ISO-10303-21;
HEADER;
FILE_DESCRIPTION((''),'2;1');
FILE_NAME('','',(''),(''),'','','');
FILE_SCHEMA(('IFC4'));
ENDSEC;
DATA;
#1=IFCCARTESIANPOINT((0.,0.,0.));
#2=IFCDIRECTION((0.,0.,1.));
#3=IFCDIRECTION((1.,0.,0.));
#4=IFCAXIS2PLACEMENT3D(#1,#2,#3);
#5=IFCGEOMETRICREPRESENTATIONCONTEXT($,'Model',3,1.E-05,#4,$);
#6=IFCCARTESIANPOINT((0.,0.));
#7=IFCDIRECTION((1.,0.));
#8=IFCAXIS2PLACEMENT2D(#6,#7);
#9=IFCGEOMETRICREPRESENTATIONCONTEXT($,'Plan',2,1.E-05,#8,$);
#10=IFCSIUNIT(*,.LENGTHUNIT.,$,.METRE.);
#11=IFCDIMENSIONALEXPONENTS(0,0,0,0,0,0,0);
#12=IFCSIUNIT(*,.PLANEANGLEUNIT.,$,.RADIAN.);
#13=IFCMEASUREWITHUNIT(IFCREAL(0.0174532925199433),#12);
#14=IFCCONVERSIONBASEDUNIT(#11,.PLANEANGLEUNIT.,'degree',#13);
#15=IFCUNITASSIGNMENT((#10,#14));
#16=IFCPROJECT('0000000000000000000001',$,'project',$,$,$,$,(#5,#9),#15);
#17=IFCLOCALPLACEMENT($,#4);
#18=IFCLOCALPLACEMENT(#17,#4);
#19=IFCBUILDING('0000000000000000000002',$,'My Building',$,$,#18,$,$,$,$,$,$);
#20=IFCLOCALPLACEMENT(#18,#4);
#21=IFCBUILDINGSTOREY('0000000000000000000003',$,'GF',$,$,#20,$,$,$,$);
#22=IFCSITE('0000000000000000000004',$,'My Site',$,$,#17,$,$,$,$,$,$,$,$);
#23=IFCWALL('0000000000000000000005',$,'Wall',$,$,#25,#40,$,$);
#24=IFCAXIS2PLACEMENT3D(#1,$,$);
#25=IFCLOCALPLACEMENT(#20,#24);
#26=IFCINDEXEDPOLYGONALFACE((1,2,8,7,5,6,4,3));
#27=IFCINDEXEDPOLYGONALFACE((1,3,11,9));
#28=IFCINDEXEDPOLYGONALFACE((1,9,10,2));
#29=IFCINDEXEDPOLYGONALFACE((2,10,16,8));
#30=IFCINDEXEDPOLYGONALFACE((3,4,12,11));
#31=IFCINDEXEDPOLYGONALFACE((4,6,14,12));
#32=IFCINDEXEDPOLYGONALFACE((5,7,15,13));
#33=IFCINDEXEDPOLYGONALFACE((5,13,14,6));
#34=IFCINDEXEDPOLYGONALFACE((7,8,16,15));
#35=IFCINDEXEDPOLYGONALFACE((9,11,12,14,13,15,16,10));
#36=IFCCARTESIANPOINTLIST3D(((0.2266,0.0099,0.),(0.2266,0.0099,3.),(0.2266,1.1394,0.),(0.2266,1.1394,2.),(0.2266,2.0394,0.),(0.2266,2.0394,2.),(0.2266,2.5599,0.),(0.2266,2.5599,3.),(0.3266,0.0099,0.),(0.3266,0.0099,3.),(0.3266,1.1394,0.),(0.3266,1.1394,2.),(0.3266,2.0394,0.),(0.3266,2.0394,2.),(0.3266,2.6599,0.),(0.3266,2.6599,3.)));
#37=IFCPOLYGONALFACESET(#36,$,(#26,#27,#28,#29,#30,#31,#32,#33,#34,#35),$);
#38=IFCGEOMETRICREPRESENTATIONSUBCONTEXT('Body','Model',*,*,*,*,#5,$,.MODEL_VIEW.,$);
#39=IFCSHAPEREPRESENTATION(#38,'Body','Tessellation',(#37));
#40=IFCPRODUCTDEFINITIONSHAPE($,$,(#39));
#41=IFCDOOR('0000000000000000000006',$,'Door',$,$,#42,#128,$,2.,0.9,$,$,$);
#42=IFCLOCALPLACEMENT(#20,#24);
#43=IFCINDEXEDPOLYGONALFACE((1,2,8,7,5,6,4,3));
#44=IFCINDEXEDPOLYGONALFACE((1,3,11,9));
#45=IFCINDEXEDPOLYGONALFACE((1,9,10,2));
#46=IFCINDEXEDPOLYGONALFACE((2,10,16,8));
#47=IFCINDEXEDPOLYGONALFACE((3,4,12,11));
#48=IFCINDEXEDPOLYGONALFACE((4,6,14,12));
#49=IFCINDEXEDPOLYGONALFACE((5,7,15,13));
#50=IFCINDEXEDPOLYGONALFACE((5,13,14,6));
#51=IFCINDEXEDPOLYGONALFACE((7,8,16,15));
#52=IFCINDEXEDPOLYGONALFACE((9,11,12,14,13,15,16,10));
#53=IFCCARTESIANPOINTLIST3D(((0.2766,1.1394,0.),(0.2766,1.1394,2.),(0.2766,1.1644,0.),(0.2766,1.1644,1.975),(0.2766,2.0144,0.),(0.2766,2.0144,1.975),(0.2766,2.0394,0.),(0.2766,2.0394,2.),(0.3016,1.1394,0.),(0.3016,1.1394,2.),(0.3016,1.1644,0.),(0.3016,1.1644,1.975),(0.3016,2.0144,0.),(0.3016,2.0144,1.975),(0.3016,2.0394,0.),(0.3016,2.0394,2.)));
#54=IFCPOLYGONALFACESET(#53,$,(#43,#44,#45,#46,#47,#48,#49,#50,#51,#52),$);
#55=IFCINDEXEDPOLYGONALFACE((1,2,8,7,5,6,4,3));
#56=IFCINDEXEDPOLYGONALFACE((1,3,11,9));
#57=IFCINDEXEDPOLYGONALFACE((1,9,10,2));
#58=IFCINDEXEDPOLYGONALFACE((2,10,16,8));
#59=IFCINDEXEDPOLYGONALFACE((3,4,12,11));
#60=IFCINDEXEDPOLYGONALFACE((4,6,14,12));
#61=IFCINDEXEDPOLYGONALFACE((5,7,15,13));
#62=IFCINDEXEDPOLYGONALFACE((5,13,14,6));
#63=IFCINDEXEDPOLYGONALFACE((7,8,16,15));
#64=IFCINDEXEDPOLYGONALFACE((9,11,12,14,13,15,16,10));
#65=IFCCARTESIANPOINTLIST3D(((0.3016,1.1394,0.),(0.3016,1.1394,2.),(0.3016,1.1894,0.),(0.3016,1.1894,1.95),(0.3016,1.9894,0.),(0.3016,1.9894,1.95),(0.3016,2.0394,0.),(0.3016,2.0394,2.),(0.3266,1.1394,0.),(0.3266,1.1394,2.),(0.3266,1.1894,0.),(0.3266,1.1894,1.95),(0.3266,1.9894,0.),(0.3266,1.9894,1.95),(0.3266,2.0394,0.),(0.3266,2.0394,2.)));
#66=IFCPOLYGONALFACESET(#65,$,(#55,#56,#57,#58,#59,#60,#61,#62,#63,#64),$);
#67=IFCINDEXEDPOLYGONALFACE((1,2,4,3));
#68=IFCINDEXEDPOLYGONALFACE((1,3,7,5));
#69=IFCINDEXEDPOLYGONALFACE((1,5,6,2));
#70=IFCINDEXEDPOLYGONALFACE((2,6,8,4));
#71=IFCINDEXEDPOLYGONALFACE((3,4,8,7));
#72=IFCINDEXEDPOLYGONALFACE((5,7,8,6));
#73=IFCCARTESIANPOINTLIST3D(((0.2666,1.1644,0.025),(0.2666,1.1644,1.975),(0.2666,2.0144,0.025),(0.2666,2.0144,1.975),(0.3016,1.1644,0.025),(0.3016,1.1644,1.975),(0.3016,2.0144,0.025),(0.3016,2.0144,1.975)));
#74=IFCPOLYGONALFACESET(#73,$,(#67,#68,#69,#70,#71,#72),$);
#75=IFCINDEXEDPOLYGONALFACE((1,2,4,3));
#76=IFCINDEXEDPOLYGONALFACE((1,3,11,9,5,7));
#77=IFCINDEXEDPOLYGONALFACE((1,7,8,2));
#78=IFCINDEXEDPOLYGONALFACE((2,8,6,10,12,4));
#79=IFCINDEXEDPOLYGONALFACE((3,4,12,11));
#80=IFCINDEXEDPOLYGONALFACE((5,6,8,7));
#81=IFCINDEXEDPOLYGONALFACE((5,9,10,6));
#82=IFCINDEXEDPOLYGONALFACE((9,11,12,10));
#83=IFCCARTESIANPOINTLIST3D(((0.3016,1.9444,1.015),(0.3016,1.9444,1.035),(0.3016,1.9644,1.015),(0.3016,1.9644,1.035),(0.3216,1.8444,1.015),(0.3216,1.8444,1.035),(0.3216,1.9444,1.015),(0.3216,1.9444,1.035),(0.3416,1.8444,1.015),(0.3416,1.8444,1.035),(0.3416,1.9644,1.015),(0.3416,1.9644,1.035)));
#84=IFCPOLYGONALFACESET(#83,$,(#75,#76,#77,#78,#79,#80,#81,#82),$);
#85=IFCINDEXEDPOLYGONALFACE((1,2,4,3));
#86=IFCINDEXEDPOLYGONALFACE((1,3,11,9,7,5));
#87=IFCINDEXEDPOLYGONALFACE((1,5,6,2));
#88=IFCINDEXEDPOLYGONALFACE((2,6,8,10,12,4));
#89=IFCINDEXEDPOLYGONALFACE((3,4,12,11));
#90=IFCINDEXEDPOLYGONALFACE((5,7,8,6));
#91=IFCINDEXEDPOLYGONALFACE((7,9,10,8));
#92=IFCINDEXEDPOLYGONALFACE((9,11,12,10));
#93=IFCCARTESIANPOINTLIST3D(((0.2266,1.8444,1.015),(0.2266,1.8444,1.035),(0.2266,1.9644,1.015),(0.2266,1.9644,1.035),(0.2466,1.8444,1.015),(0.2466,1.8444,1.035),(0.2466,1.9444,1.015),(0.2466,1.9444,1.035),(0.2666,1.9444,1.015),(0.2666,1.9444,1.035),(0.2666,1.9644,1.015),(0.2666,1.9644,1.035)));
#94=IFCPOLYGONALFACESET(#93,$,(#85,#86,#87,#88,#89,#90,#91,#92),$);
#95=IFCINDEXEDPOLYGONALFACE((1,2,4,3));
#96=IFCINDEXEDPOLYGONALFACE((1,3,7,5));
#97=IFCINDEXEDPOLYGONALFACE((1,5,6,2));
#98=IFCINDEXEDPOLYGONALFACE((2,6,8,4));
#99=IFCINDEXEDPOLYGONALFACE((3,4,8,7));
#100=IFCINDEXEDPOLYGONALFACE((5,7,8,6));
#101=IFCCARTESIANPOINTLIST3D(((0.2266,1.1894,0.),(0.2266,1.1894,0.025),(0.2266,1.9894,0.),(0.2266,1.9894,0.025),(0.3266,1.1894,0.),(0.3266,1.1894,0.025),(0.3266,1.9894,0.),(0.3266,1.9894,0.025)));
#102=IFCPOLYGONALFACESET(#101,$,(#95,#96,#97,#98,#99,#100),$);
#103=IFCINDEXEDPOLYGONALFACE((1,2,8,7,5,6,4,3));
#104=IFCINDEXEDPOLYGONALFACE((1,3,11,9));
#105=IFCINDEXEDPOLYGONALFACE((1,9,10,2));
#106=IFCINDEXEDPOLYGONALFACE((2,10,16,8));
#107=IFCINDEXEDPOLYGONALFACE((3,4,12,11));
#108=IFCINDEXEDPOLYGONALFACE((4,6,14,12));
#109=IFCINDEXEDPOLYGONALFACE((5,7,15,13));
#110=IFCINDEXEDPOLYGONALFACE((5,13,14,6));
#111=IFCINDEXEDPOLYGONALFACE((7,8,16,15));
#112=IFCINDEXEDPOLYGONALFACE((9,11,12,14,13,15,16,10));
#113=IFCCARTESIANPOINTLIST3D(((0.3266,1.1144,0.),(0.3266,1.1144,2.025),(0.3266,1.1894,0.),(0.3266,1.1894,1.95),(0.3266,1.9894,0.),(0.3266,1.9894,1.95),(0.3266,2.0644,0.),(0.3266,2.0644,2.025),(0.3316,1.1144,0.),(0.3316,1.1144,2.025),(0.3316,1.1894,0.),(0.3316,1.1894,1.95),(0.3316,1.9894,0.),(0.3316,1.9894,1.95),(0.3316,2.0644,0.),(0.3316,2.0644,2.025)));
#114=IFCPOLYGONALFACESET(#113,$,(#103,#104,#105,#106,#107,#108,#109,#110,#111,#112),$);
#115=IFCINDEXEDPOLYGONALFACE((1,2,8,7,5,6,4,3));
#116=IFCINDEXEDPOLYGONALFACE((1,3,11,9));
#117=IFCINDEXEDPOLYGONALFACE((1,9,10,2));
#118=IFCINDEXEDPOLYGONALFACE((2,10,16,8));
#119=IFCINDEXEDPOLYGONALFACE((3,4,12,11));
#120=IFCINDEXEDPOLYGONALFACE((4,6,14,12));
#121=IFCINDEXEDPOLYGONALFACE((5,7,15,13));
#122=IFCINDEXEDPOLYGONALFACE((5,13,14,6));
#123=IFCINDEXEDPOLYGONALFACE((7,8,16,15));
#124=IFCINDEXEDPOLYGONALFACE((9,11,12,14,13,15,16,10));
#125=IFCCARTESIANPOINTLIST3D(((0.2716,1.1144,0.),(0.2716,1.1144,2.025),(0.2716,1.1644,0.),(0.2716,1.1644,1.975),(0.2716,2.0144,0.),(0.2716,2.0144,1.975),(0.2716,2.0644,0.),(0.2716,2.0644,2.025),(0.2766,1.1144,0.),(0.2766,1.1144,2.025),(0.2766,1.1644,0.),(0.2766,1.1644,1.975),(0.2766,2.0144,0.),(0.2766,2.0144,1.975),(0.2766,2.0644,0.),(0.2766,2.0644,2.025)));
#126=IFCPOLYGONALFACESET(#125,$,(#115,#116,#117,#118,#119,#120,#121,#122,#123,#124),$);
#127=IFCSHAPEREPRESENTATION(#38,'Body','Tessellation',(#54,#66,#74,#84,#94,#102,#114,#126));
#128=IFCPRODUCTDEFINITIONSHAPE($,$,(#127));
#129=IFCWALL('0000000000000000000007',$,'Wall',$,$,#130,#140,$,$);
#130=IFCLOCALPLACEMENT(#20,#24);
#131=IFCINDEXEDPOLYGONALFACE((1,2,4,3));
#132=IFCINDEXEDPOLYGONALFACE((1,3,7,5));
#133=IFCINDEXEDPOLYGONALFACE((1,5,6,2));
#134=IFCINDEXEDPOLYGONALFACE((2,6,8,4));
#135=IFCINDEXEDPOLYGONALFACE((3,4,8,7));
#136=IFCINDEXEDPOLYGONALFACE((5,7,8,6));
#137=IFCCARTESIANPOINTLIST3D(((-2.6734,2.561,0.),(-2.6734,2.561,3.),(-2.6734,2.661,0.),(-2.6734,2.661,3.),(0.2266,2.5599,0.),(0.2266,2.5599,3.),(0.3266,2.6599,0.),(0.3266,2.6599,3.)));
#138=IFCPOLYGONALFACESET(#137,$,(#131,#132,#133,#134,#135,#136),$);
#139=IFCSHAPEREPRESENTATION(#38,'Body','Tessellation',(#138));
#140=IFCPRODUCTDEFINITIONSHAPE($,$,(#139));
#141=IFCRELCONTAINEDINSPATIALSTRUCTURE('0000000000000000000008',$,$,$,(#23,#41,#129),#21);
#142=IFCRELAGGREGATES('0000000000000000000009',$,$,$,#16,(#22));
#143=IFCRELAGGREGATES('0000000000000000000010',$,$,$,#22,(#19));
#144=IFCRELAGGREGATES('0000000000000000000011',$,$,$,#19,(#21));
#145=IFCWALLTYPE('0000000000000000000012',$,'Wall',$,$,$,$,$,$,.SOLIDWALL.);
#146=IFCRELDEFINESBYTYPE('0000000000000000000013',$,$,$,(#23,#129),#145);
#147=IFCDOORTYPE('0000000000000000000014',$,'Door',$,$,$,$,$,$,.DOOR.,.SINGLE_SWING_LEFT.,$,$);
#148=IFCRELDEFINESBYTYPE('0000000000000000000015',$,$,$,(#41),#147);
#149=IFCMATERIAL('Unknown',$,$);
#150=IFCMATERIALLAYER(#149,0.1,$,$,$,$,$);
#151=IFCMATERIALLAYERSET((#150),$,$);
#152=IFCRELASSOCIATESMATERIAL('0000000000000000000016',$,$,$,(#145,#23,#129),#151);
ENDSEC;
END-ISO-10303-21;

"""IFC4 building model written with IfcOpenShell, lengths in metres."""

from ifc_helpers import new_model, entity, si_unit, converted_unit, frame, origin_with_axes, origin_2d_with_axis, place, context, subcontext, project, spatial, line, indexed_curve, outline, extrude, shape, source, transform, mapped, material, layer, layer_set, layer_usage, type_object, type_shapes, element, fill, save


model = new_model("IFC4")

# Units and contexts
model_context = context("Model", 3, precision=1e-05, world=origin_with_axes())
plan_context = context("Plan", 2, precision=1e-05, world=origin_2d_with_axis())
body_context_1 = subcontext(model_context, "Body", "Model", "MODEL_VIEW")
body_context_2 = subcontext(plan_context, "Body", "Plan", "PLAN_VIEW")
ifc_project = project(units=[si_unit("LENGTHUNIT", "METRE"), converted_unit("PLANEANGLEUNIT", "degree", entity("IfcReal", 0.0174532925199433), si_unit("PLANEANGLEUNIT", "RADIAN"), dimensions=[0, 0, 0, 0, 0, 0, 0])], contexts=[model_context, plan_context])

# Site, building, storey
site_placement = place(None, origin_with_axes())
site = spatial("IfcSite", under=ifc_project, at=site_placement, Name="My Site")
building_placement = place(site_placement, origin_with_axes())
building = spatial("IfcBuilding", under=site, at=building_placement, Name="My Building")
storey_placement = place(building_placement, origin_with_axes())
storey = spatial("IfcBuildingStorey", under=building, at=storey_placement, Name="GF")

# Shared definitions
ifc_material = material(Name="Unknown")

# Shared definitions
ifc_layer_1 = layer(ifc_material, 0.1)
ifc_layer_set_1 = layer_set([ifc_layer_1])
wall_type = type_object("IfcWallType", Name="Wall", PredefinedType="SOLIDWALL", material=ifc_layer_set_1)
shared_shape_1 = source(origin_with_axes(), body_context_1, "Body", "SweptSolid", [
    extrude(outline(indexed_curve([(0.0, 0.0), (0.9, 0.0), (0.9, 2.0), (0.0, 2.0)], segments=[line(1, 2, 3, 4, 1)])), frame((0.0, -0.6, 0.0), z_axis=(0.0, -1.0, 0.0), x_axis=(1.0, 0.0, 0.0)), (0.0, 0.0, -1.0), 1.2),
])
door_type = type_object("IfcDoorType", Name="Door", OperationType="SINGLE_SWING_LEFT", PredefinedType="DOOR")
shared_shape_2 = source(origin_with_axes(), body_context_1, "Body", "SweptSolid", [
    extrude(outline(indexed_curve([(0.0, 0.0), (0.0, 2.0), (0.9, 2.0), (0.9, 0.0), (0.875, 0.0), (0.875, 1.975), (0.025, 1.975), (0.025, 0.0)], segments=[line(1, 2, 3, 4, 5, 6, 7, 8, 1)])), frame((0.0, 0.025, 0.0), z_axis=(0.0, -1.0, 0.0), x_axis=(1.0, 0.0, 0.0)), (0.0, 0.0, -1.0), 0.025),
    extrude(outline(indexed_curve([(0.0, 0.0), (0.0, 2.0), (0.9, 2.0), (0.9, 0.0), (0.85, 0.0), (0.85, 1.95), (0.05, 1.95), (0.05, 0.0)], segments=[line(1, 2, 3, 4, 5, 6, 7, 8, 1)])), frame((0.0, 0.0, 0.0), z_axis=(0.0, -1.0, 0.0), x_axis=(1.0, 0.0, 0.0)), (0.0, 0.0, -1.0), 0.025),
    extrude(outline(indexed_curve([(0.0, 0.0), (0.85, 0.0), (0.85, 0.035), (0.0, 0.035)], segments=[line(1, 2, 3, 4, 1)])), frame((0.025, 0.025, 0.025), z_axis=(0.0, 0.0, 1.0), x_axis=(1.0, 0.0, 0.0)), (0.0, 0.0, 1.0), 1.95),
    extrude(outline(indexed_curve([(0.0, 0.0), (0.0, -0.04), (-0.12, -0.04), (-0.12, -0.02), (-0.02, -0.02), (-0.02, 0.0)], segments=[line(1, 2, 3, 4, 5, 6, 1)])), frame((0.825, 0.025, 1.015), z_axis=(0.0, 0.0, 1.0), x_axis=(1.0, 0.0, 0.0)), (0.0, 0.0, 1.0), 0.02),
    extrude(outline(indexed_curve([(0.0, 0.0), (0.0, 0.04), (-0.12, 0.04), (-0.12, 0.02), (-0.02, 0.02), (-0.02, 0.0)], segments=[line(1, 2, 3, 4, 5, 6, 1)])), frame((0.825, 0.06, 1.015), z_axis=(0.0, 0.0, 1.0), x_axis=(1.0, 0.0, 0.0)), (0.0, 0.0, 1.0), 0.02),
    extrude(outline(indexed_curve([(0.0, 0.0), (0.8, 0.0), (0.8, 0.1), (0.0, 0.1)], segments=[line(1, 2, 3, 4, 1)])), frame((0.05, 0.0, 0.0), z_axis=(0.0, 0.0, 1.0), x_axis=(1.0, 0.0, 0.0)), (0.0, 0.0, 1.0), 0.025),
    extrude(outline(indexed_curve([(0.0, 0.0), (0.0, 2.025), (0.95, 2.025), (0.95, 0.0), (0.875, 0.0), (0.875, 1.95), (0.075, 1.95), (0.075, 0.0)], segments=[line(1, 2, 3, 4, 5, 6, 7, 8, 1)])), frame((-0.025, -0.005, 0.0), z_axis=(0.0, -1.0, 0.0), x_axis=(1.0, 0.0, 0.0)), (0.0, 0.0, -1.0), 0.005),
    extrude(outline(indexed_curve([(0.0, 0.0), (0.0, 2.025), (0.95, 2.025), (0.95, 0.0), (0.9, 0.0), (0.9, 1.975), (0.05, 1.975), (0.05, 0.0)], segments=[line(1, 2, 3, 4, 5, 6, 7, 8, 1)])), frame((-0.025, 0.05, 0.0), z_axis=(0.0, -1.0, 0.0), x_axis=(1.0, 0.0, 0.0)), (0.0, 0.0, -1.0), 0.005),
])
shared_shape_3 = source(origin_with_axes(), body_context_2, "Body", "Curve2D", [
    entity("IfcIndexedPolyCurve", entity("IfcCartesianPointList2D", [[0.0, 0.0], [0.0, 0.05], [0.025, 0.05], [0.025, 0.025], [0.05, 0.025], [0.05, 0.0]]), [entity("IfcLineIndex", [1, 2, 3, 4, 5, 6, 1])]),
    entity("IfcIndexedPolyCurve", entity("IfcCartesianPointList2D", [[0.9, 0.0], [0.9, 0.05], [0.875, 0.05], [0.875, 0.025], [0.85, 0.025], [0.85, 0.0]]), [entity("IfcLineIndex", [1, 2, 3, 4, 5, 6, 1])]),
    entity("IfcTrimmedCurve", entity("IfcEllipse", entity("IfcAxis2Placement2D", entity("IfcCartesianPoint", [0.06, 0.05]), entity("IfcDirection", [1.0, 0.0])), 0.815, 0.85), [entity("IfcCartesianPoint", [0.875, 0.05])], [entity("IfcCartesianPoint", [0.06, 0.9])], True, "CARTESIAN"),
    entity("IfcIndexedPolyCurve", entity("IfcCartesianPointList2D", [[0.025, 0.05], [0.06, 0.05], [0.06, 0.9], [0.025, 0.9]]), [entity("IfcLineIndex", [1, 2, 3, 4, 1])]),
])
type_shapes(door_type, [shared_shape_2, shared_shape_3])

# Wall, opening, door
ifc_layer_usage_1 = layer_usage(ifc_layer_set_1, "AXIS2", "POSITIVE", 0.0)
wall_1_placement = place(storey_placement, frame((0.3266, 0.0099, 0.0), z_axis=(0.0, 0.0, 1.0), x_axis=(0.0, 1.0, 0.0)))
wall_1 = element("IfcWall", 1, at=wall_1_placement, inside=storey, type_object=wall_type, material=ifc_layer_usage_1, Name="Wall", context=body_context_1, shape_type="SweptSolid", body=[
    extrude(outline(indexed_curve([(0.0, 0.0), (0.0, 0.1), (2.55, 0.1), (2.65, 0.0)], segments=[line(1, 2, 3, 4, 1)])), origin_with_axes(), (0.0, 0.0, 1.0), 3.0),
])
opening_1_placement = place(wall_1_placement, frame((1.1295, 0.0, 0.0), z_axis=(0.0, 0.0, 1.0), x_axis=(1.0, 0.0, 0.0)))
opening_1 = element("IfcOpeningElement", 2, at=opening_1_placement, cuts=wall_1, PredefinedType="OPENING", context=body_context_1, shape_type="MappedRepresentation", body=[
    mapped(shared_shape_1, transform((0.0, 0.0, 0.0), x_axis=(1.0, 0.0, 0.0), y_axis=(0.0, 1.0, 0.0), z_axis=(0.0, 0.0, 1.0), scale=1.0)),
])
door_1_placement = place(opening_1_placement, frame((0.0, 0.0, 0.0), z_axis=(0.0, 0.0, 1.0), x_axis=(1.0, 0.0, 0.0)))
door_1 = element("IfcDoor", 3, at=door_1_placement, inside=storey, type_object=door_type, Name="Door", OverallHeight=2.0, OverallWidth=0.9, shapes=[
    shape(body_context_1, "Body", "MappedRepresentation", [mapped(shared_shape_2, transform((0.0, 0.0, 0.0), x_axis=(1.0, 0.0, 0.0), y_axis=(0.0, 1.0, 0.0), z_axis=(0.0, 0.0, 1.0), scale=1.0))]),
    shape(body_context_2, "Body", "MappedRepresentation", [mapped(shared_shape_3, transform((0.0, 0.0, 0.0), x_axis=(1.0, 0.0, 0.0), y_axis=(0.0, 1.0, 0.0), z_axis=(0.0, 0.0, 1.0), scale=1.0))]),
])
fill(opening_1, door_1)

# Wall
ifc_layer_usage_2 = layer_usage(ifc_layer_set_1, "AXIS2", "POSITIVE", 0.0)
wall_2_placement = place(storey_placement, frame((0.3266, 2.6599, 0.0), z_axis=(0.0, 0.0, 1.0), x_axis=(-1.0, 0.000381, 0.0)))
element("IfcWall", 4, at=wall_2_placement, inside=storey, type_object=wall_type, material=ifc_layer_usage_2, Name="Wall", context=body_context_1, shape_type="SweptSolid", body=[
    extrude(outline(indexed_curve([(0.0, 0.0), (0.1, 0.1), (3.0, 0.1), (3.0, 0.0)], segments=[line(1, 2, 3, 4, 1)])), origin_with_axes(), (0.0, 0.0, 1.0), 3.0),
])

save(model, "model.ifc")
